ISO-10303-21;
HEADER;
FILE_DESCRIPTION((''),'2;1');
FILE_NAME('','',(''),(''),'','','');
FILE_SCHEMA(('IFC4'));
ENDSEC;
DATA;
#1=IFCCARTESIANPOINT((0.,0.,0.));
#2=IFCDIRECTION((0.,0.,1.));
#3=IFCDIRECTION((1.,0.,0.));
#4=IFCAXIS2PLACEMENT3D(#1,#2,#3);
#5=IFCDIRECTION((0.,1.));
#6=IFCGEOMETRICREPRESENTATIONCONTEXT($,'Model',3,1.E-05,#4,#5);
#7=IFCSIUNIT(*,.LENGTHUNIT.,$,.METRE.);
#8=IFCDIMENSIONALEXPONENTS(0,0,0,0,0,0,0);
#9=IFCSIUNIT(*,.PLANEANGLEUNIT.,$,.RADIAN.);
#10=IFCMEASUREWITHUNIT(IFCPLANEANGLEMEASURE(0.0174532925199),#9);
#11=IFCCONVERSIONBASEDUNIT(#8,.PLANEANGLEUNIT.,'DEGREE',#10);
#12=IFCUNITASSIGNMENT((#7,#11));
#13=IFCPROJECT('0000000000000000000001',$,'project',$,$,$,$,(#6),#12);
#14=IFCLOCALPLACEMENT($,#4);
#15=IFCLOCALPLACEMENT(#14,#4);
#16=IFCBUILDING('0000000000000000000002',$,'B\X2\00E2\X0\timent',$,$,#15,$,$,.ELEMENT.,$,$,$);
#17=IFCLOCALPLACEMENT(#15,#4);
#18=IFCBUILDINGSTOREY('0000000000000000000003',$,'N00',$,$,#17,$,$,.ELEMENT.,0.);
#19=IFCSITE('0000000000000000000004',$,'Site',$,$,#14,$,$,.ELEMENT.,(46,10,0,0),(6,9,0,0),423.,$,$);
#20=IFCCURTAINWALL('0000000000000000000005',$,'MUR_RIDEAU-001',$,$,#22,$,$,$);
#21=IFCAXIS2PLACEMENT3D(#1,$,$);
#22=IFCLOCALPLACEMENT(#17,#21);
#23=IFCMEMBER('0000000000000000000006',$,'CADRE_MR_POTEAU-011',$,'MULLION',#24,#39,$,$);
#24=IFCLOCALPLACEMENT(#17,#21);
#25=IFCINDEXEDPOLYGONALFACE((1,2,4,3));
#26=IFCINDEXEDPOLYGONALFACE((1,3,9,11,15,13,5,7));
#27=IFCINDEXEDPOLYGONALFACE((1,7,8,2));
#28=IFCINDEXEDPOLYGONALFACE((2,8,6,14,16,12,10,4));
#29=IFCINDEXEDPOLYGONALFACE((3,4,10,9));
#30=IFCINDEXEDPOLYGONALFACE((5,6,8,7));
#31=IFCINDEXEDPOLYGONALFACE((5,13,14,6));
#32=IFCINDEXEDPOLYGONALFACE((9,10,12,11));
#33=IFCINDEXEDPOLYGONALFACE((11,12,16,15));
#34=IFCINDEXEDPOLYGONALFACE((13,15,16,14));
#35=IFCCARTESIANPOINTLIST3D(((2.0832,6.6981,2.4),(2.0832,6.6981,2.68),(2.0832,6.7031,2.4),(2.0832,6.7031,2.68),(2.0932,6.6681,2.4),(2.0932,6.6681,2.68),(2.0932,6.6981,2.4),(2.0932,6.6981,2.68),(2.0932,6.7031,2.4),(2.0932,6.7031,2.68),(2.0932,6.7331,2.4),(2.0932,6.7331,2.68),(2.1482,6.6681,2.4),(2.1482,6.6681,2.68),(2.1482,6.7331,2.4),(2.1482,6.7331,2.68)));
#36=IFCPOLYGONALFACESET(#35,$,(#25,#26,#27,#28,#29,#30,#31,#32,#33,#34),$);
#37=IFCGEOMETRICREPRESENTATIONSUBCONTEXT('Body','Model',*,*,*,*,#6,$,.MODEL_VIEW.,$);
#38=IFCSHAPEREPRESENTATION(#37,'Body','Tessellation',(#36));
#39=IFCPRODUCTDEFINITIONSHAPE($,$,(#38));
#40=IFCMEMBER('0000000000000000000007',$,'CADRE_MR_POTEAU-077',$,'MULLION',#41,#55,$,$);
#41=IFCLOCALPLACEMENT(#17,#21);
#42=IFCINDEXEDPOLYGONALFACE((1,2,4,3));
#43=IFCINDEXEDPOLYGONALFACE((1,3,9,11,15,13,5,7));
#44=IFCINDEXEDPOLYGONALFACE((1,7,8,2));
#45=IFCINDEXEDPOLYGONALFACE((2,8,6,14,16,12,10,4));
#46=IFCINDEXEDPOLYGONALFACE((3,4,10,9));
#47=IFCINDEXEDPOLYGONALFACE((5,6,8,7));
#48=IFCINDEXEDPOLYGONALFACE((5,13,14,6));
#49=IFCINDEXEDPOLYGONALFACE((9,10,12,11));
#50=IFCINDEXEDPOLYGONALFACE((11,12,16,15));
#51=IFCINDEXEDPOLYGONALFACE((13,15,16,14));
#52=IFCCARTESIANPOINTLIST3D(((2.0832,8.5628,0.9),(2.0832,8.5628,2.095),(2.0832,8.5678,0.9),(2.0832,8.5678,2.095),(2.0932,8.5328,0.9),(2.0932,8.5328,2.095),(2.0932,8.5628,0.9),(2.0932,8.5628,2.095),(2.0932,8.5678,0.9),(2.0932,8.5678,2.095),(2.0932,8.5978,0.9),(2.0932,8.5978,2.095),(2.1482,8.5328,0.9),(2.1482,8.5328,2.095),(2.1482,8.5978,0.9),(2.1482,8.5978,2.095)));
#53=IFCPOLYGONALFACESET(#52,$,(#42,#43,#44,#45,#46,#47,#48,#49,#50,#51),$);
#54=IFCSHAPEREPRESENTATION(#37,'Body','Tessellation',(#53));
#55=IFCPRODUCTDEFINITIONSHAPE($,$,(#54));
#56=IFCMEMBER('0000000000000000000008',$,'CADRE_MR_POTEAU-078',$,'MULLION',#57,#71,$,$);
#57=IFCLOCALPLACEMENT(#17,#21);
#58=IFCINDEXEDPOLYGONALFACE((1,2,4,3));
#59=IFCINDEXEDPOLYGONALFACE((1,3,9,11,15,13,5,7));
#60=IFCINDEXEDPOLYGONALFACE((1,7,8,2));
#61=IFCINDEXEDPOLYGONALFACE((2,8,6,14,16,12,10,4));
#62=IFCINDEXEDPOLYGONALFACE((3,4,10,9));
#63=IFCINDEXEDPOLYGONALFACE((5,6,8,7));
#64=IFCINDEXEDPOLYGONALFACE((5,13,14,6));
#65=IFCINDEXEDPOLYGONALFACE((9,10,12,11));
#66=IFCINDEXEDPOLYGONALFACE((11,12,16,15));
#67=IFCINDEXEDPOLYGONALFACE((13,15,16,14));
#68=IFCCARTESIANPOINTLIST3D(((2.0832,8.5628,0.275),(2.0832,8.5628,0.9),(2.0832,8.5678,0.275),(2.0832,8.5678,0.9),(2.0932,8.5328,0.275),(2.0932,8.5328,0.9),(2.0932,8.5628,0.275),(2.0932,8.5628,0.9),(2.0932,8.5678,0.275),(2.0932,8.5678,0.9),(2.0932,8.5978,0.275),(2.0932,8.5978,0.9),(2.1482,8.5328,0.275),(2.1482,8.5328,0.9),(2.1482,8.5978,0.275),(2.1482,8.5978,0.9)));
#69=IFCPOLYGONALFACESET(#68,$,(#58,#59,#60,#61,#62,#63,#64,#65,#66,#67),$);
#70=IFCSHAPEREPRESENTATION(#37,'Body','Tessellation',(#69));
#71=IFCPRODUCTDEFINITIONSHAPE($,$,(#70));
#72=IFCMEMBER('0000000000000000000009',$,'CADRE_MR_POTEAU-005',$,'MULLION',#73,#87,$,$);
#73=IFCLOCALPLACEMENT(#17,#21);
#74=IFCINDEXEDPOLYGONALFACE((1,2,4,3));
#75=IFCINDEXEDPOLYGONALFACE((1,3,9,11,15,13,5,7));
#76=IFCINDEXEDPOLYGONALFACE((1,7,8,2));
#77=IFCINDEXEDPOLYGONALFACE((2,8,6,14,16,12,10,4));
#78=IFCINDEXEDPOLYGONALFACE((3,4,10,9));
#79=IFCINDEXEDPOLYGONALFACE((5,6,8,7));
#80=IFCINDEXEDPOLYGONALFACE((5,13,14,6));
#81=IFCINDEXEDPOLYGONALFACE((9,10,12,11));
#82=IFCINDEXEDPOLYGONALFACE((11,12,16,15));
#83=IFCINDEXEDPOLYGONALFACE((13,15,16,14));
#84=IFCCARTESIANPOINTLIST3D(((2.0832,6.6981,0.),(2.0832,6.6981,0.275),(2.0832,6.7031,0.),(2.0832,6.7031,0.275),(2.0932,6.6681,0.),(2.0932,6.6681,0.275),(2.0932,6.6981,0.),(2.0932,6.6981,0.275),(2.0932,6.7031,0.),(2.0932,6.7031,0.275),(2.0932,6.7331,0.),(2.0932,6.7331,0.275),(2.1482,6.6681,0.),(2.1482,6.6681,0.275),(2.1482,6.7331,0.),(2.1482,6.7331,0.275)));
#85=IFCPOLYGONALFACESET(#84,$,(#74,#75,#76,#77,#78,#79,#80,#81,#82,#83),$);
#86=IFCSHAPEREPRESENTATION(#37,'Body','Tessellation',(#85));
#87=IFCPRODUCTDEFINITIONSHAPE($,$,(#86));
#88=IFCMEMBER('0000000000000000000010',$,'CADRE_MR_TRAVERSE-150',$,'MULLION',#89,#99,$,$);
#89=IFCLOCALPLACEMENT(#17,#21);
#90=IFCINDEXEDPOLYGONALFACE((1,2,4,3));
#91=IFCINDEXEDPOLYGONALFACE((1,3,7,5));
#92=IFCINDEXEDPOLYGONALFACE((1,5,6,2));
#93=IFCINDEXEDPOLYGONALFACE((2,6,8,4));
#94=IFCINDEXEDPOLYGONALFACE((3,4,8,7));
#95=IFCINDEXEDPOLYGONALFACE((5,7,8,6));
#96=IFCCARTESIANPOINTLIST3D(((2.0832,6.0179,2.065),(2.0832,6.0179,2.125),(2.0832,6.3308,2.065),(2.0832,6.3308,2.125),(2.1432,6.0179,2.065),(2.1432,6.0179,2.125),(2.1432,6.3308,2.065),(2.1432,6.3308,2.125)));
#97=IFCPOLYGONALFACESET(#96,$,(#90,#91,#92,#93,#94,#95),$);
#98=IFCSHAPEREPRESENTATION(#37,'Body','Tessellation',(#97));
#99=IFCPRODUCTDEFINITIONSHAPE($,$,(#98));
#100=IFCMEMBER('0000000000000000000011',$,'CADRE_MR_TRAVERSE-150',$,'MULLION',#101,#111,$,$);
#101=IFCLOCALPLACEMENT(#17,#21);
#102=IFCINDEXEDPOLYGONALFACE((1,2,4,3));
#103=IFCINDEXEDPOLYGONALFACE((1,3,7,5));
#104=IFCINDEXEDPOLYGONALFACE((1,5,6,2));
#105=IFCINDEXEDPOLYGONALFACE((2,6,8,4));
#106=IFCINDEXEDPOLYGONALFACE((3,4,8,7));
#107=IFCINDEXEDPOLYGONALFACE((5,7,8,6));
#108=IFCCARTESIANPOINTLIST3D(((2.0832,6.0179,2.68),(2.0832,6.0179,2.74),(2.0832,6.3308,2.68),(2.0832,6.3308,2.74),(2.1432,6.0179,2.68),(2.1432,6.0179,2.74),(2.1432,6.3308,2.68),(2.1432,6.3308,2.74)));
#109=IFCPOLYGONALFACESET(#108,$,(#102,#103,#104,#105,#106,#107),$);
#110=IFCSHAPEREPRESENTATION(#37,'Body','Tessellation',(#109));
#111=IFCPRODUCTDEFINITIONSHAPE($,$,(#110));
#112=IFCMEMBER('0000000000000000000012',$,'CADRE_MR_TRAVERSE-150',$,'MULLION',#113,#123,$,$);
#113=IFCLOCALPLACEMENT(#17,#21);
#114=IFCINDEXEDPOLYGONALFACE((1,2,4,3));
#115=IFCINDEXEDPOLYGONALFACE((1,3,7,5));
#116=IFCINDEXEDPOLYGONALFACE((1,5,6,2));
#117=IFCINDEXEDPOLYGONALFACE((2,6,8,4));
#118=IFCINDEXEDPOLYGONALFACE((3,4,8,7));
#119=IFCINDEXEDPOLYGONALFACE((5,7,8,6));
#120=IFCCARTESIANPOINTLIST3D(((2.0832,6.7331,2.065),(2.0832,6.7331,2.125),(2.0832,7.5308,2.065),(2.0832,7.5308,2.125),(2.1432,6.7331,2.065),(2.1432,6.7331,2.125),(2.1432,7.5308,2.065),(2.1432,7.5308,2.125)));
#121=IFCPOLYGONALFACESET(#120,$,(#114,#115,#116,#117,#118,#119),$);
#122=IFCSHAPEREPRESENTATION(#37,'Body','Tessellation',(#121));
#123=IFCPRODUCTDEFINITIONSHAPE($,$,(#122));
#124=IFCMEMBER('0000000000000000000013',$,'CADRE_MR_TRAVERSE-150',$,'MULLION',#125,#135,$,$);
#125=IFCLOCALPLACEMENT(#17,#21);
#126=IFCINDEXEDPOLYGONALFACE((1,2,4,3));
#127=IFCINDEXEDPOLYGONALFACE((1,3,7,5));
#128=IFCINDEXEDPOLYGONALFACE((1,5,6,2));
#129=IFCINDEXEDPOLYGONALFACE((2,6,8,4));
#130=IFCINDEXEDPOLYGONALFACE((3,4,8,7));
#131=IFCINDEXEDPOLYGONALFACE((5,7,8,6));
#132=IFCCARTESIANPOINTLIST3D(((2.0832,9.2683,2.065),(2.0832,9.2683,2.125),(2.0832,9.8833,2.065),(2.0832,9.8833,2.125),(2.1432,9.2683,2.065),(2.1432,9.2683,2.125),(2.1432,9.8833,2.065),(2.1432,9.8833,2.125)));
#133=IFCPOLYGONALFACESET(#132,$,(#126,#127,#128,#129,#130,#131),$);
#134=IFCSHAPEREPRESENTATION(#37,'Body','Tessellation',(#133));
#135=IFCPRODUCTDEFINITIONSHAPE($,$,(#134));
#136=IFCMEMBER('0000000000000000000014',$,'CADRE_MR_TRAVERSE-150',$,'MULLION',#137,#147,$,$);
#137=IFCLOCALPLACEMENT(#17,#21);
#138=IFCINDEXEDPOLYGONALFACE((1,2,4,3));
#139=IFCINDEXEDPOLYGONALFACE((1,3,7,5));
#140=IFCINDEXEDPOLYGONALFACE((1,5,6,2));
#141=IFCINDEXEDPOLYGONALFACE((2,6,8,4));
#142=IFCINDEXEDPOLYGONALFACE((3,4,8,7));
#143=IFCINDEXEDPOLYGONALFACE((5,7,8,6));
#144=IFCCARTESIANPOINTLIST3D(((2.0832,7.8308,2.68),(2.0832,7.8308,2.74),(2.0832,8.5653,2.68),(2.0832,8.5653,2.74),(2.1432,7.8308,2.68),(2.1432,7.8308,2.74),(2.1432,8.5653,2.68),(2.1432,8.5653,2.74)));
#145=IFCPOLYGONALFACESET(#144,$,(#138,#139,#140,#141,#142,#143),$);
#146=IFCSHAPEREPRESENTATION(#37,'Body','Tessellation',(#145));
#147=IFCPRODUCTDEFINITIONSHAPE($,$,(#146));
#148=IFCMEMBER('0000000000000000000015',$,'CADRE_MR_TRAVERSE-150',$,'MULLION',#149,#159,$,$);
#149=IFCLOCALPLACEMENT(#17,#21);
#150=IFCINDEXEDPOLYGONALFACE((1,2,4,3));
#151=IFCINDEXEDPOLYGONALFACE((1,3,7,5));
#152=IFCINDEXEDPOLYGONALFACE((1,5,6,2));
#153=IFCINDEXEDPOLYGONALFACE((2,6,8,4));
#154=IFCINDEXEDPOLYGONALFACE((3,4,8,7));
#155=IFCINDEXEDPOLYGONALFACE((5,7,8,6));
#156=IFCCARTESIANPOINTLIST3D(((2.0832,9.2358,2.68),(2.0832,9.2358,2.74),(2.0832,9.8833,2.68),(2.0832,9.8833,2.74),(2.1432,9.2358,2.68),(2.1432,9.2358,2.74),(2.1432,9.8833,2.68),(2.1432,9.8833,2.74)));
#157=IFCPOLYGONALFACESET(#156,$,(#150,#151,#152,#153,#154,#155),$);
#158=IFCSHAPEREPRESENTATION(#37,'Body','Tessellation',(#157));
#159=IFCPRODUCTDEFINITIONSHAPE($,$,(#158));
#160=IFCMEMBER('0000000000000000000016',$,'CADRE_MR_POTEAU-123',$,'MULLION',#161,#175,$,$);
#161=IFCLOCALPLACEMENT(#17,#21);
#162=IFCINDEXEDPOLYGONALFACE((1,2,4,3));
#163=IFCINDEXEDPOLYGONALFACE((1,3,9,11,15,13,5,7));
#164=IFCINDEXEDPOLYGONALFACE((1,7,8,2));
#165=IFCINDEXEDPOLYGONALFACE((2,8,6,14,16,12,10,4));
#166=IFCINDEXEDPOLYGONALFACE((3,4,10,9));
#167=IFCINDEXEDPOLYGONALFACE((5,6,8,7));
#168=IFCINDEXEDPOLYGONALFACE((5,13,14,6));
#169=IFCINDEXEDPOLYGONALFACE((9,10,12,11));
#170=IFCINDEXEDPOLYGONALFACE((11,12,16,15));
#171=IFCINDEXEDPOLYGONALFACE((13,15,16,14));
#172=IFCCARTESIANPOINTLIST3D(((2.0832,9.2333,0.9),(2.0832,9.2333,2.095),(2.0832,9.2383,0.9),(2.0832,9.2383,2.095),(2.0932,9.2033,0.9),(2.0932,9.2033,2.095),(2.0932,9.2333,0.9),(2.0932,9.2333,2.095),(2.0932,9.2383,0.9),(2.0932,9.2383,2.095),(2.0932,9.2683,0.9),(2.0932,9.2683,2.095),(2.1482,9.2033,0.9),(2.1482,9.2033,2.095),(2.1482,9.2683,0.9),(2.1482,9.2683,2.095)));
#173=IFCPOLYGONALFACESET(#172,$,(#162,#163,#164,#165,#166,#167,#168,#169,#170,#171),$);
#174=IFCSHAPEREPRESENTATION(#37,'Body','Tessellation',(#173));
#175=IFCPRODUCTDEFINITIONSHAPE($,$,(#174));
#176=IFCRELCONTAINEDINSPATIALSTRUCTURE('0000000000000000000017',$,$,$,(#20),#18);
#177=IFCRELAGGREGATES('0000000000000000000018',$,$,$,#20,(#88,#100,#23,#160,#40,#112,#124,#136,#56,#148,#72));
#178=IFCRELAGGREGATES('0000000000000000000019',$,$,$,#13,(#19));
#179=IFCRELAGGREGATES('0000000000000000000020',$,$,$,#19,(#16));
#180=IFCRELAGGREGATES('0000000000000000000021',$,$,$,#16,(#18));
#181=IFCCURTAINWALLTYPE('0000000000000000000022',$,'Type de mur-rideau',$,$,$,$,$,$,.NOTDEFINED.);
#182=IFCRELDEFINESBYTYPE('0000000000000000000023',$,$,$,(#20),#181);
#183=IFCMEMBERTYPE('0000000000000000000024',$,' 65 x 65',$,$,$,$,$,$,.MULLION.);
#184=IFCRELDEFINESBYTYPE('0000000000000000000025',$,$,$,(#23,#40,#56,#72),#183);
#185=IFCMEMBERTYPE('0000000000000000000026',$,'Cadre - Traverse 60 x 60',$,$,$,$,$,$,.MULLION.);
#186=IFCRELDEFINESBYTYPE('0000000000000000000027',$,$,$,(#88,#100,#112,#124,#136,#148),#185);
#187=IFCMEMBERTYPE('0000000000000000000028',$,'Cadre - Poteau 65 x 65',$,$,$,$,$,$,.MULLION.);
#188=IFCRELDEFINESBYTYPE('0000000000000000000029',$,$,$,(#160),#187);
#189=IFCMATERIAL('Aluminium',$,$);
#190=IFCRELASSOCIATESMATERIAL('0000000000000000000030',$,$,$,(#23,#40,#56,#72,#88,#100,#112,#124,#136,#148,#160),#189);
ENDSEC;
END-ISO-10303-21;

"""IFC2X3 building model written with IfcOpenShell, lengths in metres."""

from ifc_helpers import new_model, entity, si_unit, converted_unit, direction, frame, origin_with_axes, place, context, subcontext, project, spatial, polyline, outline, extrude, material, type_object, element, aggregate, save


model = new_model("IFC2X3")

# Units and contexts
model_context = context("Model", 3, precision=1e-05, world=origin_with_axes(), true_north=direction((0.0, 1.0)))
body_context = subcontext(model_context, "Body", "Model", "MODEL_VIEW")
ifc_project = project(units=[si_unit("LENGTHUNIT", "METRE"), converted_unit("PLANEANGLEUNIT", "DEGREE", entity("IfcPlaneAngleMeasure", 0.0174532925199), si_unit("PLANEANGLEUNIT", "RADIAN"), dimensions=[0, 0, 0, 0, 0, 0, 0])], contexts=[model_context])

# Site, building, storey
site_placement = place(None, origin_with_axes())
site = spatial("IfcSite", under=ifc_project, at=site_placement, Name="Site", CompositionType="ELEMENT", RefLatitude=(46, 10, 0, 0), RefLongitude=(6, 9, 0, 0), RefElevation=423.0)
building_placement = place(site_placement, origin_with_axes())
building = spatial("IfcBuilding", under=site, at=building_placement, Name="Bâtiment", CompositionType="ELEMENT")
storey_placement = place(building_placement, origin_with_axes())
storey = spatial("IfcBuildingStorey", under=building, at=storey_placement, Name="N00", CompositionType="ELEMENT", Elevation=0.0)

# Curtain wall, members
curtain_wall_type = type_object("IfcCurtainWallType", Name="Type de mur-rideau", PredefinedType="NOTDEFINED")
curtain_wall_placement = place(storey_placement, frame((2.0832, 6.4208, 0.0), z_axis=(0.0, 0.0, 1.0), x_axis=(1.0, 0.0, 0.0)))
curtain_wall = element("IfcCurtainWall", 1, at=curtain_wall_placement, inside=storey, type_object=curtain_wall_type, Name="MUR_RIDEAU-001")
ifc_material = material(Name="Aluminium")
member_type_1 = type_object("IfcMemberType", Name=" 65 x 65", PredefinedType="MULLION")
member_1_placement = place(curtain_wall_placement, frame((0.0, 0.2798, 2.4), z_axis=(0.0, 0.0, 1.0), x_axis=(0.0, 1.0, 0.0)))
member_1 = element("IfcMember", 2, at=member_1_placement, type_object=member_type_1, material=ifc_material, Name="CADRE_MR_POTEAU-011", ObjectType="MULLION", context=body_context, shape_type="SweptSolid", body=[
    extrude(outline(polyline([(0.01, -0.0025), (0.01, -0.0325), (0.065, -0.0325), (0.065, 0.0325), (0.01, 0.0325), (0.01, 0.0025), (0.0, 0.0025), (0.0, -0.0025), (0.01, -0.0025)])), frame((0.0, 0.0, 0.0), z_axis=(0.0, 0.0, 1.0), x_axis=(0.0, -1.0, 0.0)), (0.0, 0.0, 1.0), 0.28),
])
member_2_placement = place(curtain_wall_placement, frame((0.0, 2.1445, 0.9), z_axis=(0.0, 0.0, 1.0), x_axis=(0.0, 1.0, 0.0)))
member_2 = element("IfcMember", 3, at=member_2_placement, type_object=member_type_1, material=ifc_material, Name="CADRE_MR_POTEAU-077", ObjectType="MULLION", context=body_context, shape_type="SweptSolid", body=[
    extrude(outline(polyline([(0.01, -0.0025), (0.01, -0.0325), (0.065, -0.0325), (0.065, 0.0325), (0.01, 0.0325), (0.01, 0.0025), (0.0, 0.0025), (0.0, -0.0025), (0.01, -0.0025)])), frame((0.0, 0.0, 0.0), z_axis=(0.0, 0.0, 1.0), x_axis=(0.0, -1.0, 0.0)), (0.0, 0.0, 1.0), 1.195),
])
member_3_placement = place(curtain_wall_placement, frame((0.0, 2.1445, 0.275), z_axis=(0.0, 0.0, 1.0), x_axis=(0.0, 1.0, 0.0)))
member_3 = element("IfcMember", 4, at=member_3_placement, type_object=member_type_1, material=ifc_material, Name="CADRE_MR_POTEAU-078", ObjectType="MULLION", context=body_context, shape_type="SweptSolid", body=[
    extrude(outline(polyline([(0.01, -0.0025), (0.01, -0.0325), (0.065, -0.0325), (0.065, 0.0325), (0.01, 0.0325), (0.01, 0.0025), (0.0, 0.0025), (0.0, -0.0025), (0.01, -0.0025)])), frame((0.0, 0.0, 0.0), z_axis=(0.0, 0.0, 1.0), x_axis=(0.0, -1.0, 0.0)), (0.0, 0.0, 1.0), 0.625),
])
member_4_placement = place(curtain_wall_placement, frame((0.0, 0.2798, 0.0), z_axis=(0.0, 0.0, 1.0), x_axis=(0.0, 1.0, 0.0)))
member_4 = element("IfcMember", 5, at=member_4_placement, type_object=member_type_1, material=ifc_material, Name="CADRE_MR_POTEAU-005", ObjectType="MULLION", context=body_context, shape_type="SweptSolid", body=[
    extrude(outline(polyline([(0.01, -0.0025), (0.01, -0.0325), (0.065, -0.0325), (0.065, 0.0325), (0.01, 0.0325), (0.01, 0.0025), (0.0, 0.0025), (0.0, -0.0025), (0.01, -0.0025)])), frame((0.0, 0.0, 0.0), z_axis=(0.0, 0.0, 1.0), x_axis=(0.0, -1.0, 0.0)), (0.0, 0.0, 1.0), 0.275),
])
member_type_2 = type_object("IfcMemberType", Name="Cadre - Traverse 60 x 60", PredefinedType="MULLION")
member_5_placement = place(curtain_wall_placement, frame((0.0, -0.0901, 2.095), z_axis=(0.0, -1.0, 0.0), x_axis=(0.0, 0.0, 1.0)))
member_5 = element("IfcMember", 6, at=member_5_placement, type_object=member_type_2, material=ifc_material, Name="CADRE_MR_TRAVERSE-150", ObjectType="MULLION", context=body_context, shape_type="SweptSolid", body=[
    extrude(outline(polyline([(-0.06, -0.03), (0.0, -0.03), (0.0, 0.03), (-0.06, 0.03), (-0.06, -0.03)])), frame((0.0, 0.0, 0.0), z_axis=(0.0, 0.0, 1.0), x_axis=(0.0, 1.0, 0.0)), (0.0, 0.0, 1.0), 0.3128),
])
member_6_placement = place(curtain_wall_placement, frame((0.0, -0.0901, 2.71), z_axis=(0.0, -1.0, 0.0), x_axis=(0.0, 0.0, 1.0)))
member_6 = element("IfcMember", 7, at=member_6_placement, type_object=member_type_2, material=ifc_material, Name="CADRE_MR_TRAVERSE-150", ObjectType="MULLION", context=body_context, shape_type="SweptSolid", body=[
    extrude(outline(polyline([(-0.06, -0.03), (0.0, -0.03), (0.0, 0.03), (-0.06, 0.03), (-0.06, -0.03)])), frame((0.0, 0.0, 0.0), z_axis=(0.0, 0.0, 1.0), x_axis=(0.0, 1.0, 0.0)), (0.0, 0.0, 1.0), 0.3128),
])
member_7_placement = place(curtain_wall_placement, frame((0.0, 1.1099, 2.095), z_axis=(0.0, -1.0, 0.0), x_axis=(0.0, 0.0, 1.0)))
member_7 = element("IfcMember", 8, at=member_7_placement, type_object=member_type_2, material=ifc_material, Name="CADRE_MR_TRAVERSE-150", ObjectType="MULLION", context=body_context, shape_type="SweptSolid", body=[
    extrude(outline(polyline([(-0.06, -0.03), (0.0, -0.03), (0.0, 0.03), (-0.06, 0.03), (-0.06, -0.03)])), frame((0.0, 0.0, 0.0), z_axis=(0.0, 0.0, 1.0), x_axis=(0.0, 1.0, 0.0)), (0.0, 0.0, 1.0), 0.7976),
])
member_8_placement = place(curtain_wall_placement, frame((0.0, 3.5099, 2.095), z_axis=(0.0, -1.0, 0.0), x_axis=(0.0, 0.0, 1.0)))
member_8 = element("IfcMember", 9, at=member_8_placement, type_object=member_type_2, material=ifc_material, Name="CADRE_MR_TRAVERSE-150", ObjectType="MULLION", context=body_context, shape_type="SweptSolid", body=[
    extrude(outline(polyline([(-0.06, -0.03), (0.0, -0.03), (0.0, 0.03), (-0.06, 0.03), (-0.06, -0.03)])), frame((0.0, 0.0, 0.0475), z_axis=(0.0, 0.0, 1.0), x_axis=(0.0, 1.0, 0.0)), (0.0, 0.0, 1.0), 0.615),
])
member_9_placement = place(curtain_wall_placement, frame((0.0, 2.1445, 2.71), z_axis=(0.0, -1.0, 0.0), x_axis=(0.0, 0.0, 1.0)))
member_9 = element("IfcMember", 10, at=member_9_placement, type_object=member_type_2, material=ifc_material, Name="CADRE_MR_TRAVERSE-150", ObjectType="MULLION", context=body_context, shape_type="SweptSolid", body=[
    extrude(outline(polyline([(-0.06, -0.03), (0.0, -0.03), (0.0, 0.03), (-0.06, 0.03), (-0.06, -0.03)])), frame((0.0, 0.0, 0.0), z_axis=(0.0, 0.0, 1.0), x_axis=(0.0, 1.0, 0.0)), (0.0, 0.0, 1.0), 0.7346),
])
member_10_placement = place(curtain_wall_placement, frame((0.0, 3.5099, 2.71), z_axis=(0.0, -1.0, 0.0), x_axis=(0.0, 0.0, 1.0)))
member_10 = element("IfcMember", 11, at=member_10_placement, type_object=member_type_2, material=ifc_material, Name="CADRE_MR_TRAVERSE-150", ObjectType="MULLION", context=body_context, shape_type="SweptSolid", body=[
    extrude(outline(polyline([(-0.06, -0.03), (0.0, -0.03), (0.0, 0.03), (-0.06, 0.03), (-0.06, -0.03)])), frame((0.0, 0.0, 0.0475), z_axis=(0.0, 0.0, 1.0), x_axis=(0.0, 1.0, 0.0)), (0.0, 0.0, 1.0), 0.6475),
])
member_type_3 = type_object("IfcMemberType", Name="Cadre - Poteau 65 x 65", PredefinedType="MULLION")
member_11_placement = place(curtain_wall_placement, frame((0.0, 2.8149, 0.9), z_axis=(0.0, 0.0, 1.0), x_axis=(0.0, 1.0, 0.0)))
member_11 = element("IfcMember", 12, at=member_11_placement, type_object=member_type_3, material=ifc_material, Name="CADRE_MR_POTEAU-123", ObjectType="MULLION", context=body_context, shape_type="SweptSolid", body=[
    extrude(outline(polyline([(0.01, -0.0025), (0.01, -0.0325), (0.065, -0.0325), (0.065, 0.0325), (0.01, 0.0325), (0.01, 0.0025), (0.0, 0.0025), (0.0, -0.0025), (0.01, -0.0025)])), frame((0.0, 0.0, 0.0), z_axis=(0.0, 0.0, 1.0), x_axis=(0.0, -1.0, 0.0)), (0.0, 0.0, 1.0), 1.195),
])
aggregate(curtain_wall, [member_5, member_6, member_1, member_11, member_2, member_7, member_8, member_9, member_3, member_10, member_4])

save(model, "model.ifc")
